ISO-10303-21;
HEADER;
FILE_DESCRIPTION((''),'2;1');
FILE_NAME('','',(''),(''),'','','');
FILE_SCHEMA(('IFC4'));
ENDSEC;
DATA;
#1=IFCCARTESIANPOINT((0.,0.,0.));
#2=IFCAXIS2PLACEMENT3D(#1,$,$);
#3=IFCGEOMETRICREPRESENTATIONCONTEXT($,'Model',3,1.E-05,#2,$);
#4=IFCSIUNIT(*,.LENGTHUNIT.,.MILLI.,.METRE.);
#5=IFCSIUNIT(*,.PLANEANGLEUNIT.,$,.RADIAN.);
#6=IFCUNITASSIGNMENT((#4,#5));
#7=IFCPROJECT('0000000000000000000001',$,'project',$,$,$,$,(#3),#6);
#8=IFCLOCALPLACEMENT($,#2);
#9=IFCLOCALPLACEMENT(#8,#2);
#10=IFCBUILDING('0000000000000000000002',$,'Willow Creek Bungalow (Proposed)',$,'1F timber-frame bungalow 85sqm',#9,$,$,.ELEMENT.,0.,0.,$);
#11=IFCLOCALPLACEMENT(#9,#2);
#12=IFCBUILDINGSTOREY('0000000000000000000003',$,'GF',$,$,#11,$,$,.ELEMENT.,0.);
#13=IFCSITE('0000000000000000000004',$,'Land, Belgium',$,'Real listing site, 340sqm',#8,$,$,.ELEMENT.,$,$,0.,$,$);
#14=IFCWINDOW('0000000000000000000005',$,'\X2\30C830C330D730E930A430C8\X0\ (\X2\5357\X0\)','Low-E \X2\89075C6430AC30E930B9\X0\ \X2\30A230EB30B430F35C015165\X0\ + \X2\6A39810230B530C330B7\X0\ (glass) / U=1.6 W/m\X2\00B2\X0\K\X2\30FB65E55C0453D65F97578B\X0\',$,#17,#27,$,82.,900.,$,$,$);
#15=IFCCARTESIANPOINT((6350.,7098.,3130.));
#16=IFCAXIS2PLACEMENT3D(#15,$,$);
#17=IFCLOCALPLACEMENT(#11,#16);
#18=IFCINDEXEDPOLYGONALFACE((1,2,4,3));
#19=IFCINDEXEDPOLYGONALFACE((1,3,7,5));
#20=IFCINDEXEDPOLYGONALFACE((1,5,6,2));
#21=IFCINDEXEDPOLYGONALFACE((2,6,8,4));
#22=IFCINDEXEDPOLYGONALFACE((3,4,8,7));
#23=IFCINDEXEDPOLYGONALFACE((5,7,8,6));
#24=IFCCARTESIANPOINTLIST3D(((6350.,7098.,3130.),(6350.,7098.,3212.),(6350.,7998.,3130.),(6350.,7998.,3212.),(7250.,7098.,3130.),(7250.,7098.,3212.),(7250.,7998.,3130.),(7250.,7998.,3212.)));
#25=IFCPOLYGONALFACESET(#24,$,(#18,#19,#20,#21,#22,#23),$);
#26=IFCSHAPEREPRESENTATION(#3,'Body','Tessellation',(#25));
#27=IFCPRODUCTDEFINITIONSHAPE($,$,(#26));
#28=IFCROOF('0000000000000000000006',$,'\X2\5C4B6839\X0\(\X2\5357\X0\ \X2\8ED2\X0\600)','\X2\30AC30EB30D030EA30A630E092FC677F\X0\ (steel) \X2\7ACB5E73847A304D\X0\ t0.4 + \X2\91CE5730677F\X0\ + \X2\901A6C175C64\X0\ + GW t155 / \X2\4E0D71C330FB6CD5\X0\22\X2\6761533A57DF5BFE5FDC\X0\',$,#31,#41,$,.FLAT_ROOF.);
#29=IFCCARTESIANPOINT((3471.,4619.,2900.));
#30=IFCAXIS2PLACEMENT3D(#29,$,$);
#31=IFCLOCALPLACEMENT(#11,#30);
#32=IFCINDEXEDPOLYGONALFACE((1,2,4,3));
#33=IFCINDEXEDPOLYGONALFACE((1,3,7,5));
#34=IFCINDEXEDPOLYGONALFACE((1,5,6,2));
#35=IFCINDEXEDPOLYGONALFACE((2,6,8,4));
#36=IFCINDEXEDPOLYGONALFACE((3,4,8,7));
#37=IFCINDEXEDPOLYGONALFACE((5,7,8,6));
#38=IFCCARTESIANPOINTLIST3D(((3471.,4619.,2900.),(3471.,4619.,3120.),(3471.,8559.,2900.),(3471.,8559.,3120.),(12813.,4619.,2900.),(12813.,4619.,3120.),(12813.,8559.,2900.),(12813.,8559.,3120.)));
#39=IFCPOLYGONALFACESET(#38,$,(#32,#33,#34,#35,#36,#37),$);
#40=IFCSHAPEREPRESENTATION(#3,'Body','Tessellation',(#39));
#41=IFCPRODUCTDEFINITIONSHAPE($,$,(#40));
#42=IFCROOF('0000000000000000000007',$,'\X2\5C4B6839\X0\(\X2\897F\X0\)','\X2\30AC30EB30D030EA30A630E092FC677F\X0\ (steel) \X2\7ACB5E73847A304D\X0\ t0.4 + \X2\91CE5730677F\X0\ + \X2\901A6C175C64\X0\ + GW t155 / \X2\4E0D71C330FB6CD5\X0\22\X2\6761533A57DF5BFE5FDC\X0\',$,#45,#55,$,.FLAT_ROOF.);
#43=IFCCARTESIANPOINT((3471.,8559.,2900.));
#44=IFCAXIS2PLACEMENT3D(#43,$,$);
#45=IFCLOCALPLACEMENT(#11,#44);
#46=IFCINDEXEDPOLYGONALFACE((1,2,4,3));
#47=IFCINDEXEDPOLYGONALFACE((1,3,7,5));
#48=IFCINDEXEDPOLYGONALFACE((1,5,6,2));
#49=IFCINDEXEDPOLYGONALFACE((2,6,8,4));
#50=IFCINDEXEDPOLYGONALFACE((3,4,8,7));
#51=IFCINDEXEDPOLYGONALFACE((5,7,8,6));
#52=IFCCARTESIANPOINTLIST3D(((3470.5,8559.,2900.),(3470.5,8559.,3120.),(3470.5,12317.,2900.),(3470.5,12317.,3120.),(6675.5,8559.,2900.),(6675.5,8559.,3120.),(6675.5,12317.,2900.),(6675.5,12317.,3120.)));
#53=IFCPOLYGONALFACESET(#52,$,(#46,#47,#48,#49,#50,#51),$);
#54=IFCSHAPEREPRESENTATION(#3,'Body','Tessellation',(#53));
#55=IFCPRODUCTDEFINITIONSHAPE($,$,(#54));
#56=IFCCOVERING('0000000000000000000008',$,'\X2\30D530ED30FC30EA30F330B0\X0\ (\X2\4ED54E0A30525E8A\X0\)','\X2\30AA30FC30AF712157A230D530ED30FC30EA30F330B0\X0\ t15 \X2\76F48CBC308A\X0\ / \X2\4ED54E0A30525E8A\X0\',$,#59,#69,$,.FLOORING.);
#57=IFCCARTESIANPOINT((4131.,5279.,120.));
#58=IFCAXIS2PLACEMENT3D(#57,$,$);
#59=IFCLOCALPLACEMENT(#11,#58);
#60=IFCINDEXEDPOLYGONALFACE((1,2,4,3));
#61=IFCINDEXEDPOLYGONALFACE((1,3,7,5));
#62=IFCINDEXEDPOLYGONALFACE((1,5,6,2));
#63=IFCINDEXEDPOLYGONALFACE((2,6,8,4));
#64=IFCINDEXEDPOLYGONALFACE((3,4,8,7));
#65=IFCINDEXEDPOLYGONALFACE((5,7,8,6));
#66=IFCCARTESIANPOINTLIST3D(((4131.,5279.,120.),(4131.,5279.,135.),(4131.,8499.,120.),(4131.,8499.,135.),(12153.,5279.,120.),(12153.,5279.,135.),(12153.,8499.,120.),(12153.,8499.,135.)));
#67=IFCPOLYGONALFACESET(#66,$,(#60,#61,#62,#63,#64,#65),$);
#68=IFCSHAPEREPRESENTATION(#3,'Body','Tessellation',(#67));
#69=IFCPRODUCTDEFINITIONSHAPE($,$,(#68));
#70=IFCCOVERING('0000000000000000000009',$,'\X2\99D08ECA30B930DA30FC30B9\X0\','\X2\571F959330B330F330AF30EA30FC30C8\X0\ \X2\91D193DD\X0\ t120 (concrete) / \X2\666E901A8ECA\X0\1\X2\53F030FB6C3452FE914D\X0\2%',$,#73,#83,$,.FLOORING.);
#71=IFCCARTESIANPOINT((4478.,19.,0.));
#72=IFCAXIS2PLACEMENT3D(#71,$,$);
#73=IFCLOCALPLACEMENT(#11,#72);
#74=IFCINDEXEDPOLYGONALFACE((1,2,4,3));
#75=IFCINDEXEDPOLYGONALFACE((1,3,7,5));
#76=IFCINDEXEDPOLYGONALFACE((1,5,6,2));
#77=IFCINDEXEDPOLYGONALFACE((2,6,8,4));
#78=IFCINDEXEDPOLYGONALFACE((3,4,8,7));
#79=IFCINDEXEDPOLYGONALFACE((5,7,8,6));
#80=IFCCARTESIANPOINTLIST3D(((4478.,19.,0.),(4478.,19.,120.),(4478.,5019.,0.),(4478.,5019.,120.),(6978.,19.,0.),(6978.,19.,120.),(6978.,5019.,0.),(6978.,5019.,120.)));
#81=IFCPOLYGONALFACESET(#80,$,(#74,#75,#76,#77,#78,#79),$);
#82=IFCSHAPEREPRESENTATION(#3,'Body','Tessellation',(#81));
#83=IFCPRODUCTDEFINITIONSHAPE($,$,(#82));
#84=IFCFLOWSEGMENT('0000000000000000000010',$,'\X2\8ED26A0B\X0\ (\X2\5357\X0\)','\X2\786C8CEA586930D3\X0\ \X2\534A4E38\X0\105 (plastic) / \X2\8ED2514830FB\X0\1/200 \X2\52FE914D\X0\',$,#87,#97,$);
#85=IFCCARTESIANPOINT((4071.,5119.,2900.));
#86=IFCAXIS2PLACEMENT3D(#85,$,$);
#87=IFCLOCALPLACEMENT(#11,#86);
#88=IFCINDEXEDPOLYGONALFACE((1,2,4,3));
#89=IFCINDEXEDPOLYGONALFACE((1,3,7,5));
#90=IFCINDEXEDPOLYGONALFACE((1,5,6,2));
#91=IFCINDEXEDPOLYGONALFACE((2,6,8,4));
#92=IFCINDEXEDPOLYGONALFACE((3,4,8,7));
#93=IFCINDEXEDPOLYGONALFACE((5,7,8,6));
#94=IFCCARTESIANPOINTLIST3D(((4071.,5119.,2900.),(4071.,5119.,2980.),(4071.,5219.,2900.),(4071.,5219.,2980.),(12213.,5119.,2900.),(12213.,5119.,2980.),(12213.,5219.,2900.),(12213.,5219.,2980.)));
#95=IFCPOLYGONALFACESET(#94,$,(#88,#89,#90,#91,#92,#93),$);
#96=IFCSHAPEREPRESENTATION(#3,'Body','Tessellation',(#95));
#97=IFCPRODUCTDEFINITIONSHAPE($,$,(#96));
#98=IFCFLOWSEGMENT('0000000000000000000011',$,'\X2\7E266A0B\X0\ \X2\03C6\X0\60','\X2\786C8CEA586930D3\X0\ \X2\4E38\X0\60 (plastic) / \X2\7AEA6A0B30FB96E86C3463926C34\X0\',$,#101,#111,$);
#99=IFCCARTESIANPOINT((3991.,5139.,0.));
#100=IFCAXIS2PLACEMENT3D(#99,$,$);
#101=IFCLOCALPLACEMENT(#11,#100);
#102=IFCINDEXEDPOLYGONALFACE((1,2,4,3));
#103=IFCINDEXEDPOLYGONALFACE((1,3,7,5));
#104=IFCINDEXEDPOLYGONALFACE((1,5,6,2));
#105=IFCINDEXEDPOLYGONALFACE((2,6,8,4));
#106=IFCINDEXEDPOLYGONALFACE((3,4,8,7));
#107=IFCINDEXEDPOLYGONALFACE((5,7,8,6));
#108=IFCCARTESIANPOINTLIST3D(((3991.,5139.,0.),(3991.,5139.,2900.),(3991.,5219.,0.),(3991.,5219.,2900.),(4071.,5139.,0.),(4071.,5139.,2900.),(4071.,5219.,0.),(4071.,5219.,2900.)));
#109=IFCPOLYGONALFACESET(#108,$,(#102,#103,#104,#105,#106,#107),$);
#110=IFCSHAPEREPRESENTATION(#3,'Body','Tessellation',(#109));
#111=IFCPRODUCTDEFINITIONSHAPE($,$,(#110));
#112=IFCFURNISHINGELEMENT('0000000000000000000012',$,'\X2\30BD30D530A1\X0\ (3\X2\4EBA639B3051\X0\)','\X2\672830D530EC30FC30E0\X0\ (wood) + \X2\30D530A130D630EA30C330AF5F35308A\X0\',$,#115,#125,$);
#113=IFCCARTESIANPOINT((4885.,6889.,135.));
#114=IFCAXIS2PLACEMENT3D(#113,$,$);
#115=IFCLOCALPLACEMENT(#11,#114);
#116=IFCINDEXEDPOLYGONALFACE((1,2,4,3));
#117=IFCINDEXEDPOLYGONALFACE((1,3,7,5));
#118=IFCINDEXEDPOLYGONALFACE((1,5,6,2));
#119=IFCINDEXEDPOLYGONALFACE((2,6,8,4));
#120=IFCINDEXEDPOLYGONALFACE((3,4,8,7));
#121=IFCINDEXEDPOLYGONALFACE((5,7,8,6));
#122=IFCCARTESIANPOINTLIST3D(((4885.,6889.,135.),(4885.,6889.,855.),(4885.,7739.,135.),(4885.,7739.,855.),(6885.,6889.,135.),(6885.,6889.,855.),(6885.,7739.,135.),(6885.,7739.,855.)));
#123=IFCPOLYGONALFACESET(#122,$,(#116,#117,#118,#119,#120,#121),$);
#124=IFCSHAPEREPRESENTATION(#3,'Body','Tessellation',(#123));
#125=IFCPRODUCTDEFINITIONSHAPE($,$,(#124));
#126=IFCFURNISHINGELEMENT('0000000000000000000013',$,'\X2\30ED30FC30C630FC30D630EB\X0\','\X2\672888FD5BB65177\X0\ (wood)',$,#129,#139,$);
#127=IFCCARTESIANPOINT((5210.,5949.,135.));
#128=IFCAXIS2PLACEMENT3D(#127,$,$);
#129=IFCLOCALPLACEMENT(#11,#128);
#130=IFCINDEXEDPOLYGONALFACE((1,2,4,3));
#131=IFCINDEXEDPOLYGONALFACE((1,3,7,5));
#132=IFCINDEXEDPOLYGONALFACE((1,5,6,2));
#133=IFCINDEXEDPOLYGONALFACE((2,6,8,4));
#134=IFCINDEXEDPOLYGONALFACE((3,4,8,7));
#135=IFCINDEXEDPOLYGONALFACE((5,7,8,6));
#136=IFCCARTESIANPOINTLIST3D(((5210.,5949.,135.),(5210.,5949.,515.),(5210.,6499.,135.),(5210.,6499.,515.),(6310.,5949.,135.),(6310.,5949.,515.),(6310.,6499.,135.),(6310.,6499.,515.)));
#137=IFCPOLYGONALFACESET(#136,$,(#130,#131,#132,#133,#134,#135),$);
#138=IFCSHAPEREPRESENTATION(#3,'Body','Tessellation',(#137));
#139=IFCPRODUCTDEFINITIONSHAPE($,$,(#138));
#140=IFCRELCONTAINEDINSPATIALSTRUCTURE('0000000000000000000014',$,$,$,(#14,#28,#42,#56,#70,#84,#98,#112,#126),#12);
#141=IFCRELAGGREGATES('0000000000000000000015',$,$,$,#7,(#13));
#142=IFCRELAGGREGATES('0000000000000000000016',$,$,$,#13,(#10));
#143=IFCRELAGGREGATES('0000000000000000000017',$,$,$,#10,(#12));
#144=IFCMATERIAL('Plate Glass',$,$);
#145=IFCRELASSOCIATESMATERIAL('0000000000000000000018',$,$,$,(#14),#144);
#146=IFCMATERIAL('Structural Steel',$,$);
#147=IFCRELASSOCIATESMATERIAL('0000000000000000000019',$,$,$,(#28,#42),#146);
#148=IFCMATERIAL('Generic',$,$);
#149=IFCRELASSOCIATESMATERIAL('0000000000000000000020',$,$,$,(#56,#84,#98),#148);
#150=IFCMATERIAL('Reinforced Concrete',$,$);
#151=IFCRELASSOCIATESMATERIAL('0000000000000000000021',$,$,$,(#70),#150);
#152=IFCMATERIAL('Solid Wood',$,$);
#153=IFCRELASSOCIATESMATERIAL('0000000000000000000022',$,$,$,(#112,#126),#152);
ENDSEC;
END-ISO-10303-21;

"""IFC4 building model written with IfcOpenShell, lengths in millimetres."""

from ifc_helpers import new_model, si_unit, frame, frame_2d, origin, place, context, project, spatial, rectangle, extrude, material, element, save


model = new_model("IFC4")

# Units and contexts
model_context = context("Model", 3, precision=1e-05, world=origin())
ifc_project = project(units=[si_unit("LENGTHUNIT", "METRE", prefix="MILLI"), si_unit("PLANEANGLEUNIT", "RADIAN")], contexts=[model_context])

# Site, building, storey
site_placement = place(None, origin())
site = spatial("IfcSite", under=ifc_project, at=site_placement, Name="Land, Belgium", ObjectType="Real listing site, 340sqm", CompositionType="ELEMENT", RefElevation=0.0)
building_placement = place(site_placement, origin())
building = spatial("IfcBuilding", under=site, at=building_placement, Name="Willow Creek Bungalow (Proposed)", ObjectType="1F timber-frame bungalow 85sqm", CompositionType="ELEMENT", ElevationOfRefHeight=0.0, ElevationOfTerrain=0.0)
storey_placement = place(building_placement, origin())
storey = spatial("IfcBuildingStorey", under=building, at=storey_placement, Name="GF", CompositionType="ELEMENT", Elevation=0.0)

# Shared definitions
ifc_material_1 = material(Name="Solid Wood")

# Shared definitions
ifc_material_2 = material(Name="Reinforced Concrete")

# Shared definitions
ifc_material_3 = material(Name="Plate Glass")

# Window
window_1_placement = place(storey_placement, frame((6350.0, 7098.0, 3130.0)))
element("IfcWindow", 1, at=window_1_placement, inside=storey, material=ifc_material_3, Name="トップライト (南)", Description="Low-E 複層ガラス アルゴン封入 + 樹脂サッシ (glass) / U=1.6 W/m²K・日射取得型", OverallHeight=82.0, OverallWidth=900.0, context=model_context, shape_type="SweptSolid", body=[
    extrude(rectangle(XDim=900.0, YDim=900.0, at=frame_2d((450.0, 450.0))), frame((6350.0, 7098.0, 3130.0)), (0.0, 0.0, 1.0), 82.0),
])

# Roofs
ifc_material_4 = material(Name="Structural Steel")
roof_1_placement = place(storey_placement, frame((3471.0, 4619.0, 2900.0)))
element("IfcRoof", 2, at=roof_1_placement, inside=storey, material=ifc_material_4, Name="屋根(南 軒600)", Description="ガルバリウム鋼板 (steel) 立平葺き t0.4 + 野地板 + 通気層 + GW t155 / 不燃・法22条区域対応", PredefinedType="FLAT_ROOF", context=model_context, shape_type="SweptSolid", body=[
    extrude(rectangle(XDim=9342.0, YDim=3940.0, at=frame_2d((4671.0, 1970.0))), frame((3471.0, 4619.0, 2900.0)), (0.0, 0.0, 1.0), 220.0),
])
roof_2_placement = place(storey_placement, frame((3471.0, 8559.0, 2900.0)))
element("IfcRoof", 3, at=roof_2_placement, inside=storey, material=ifc_material_4, Name="屋根(西)", Description="ガルバリウム鋼板 (steel) 立平葺き t0.4 + 野地板 + 通気層 + GW t155 / 不燃・法22条区域対応", PredefinedType="FLAT_ROOF", context=model_context, shape_type="SweptSolid", body=[
    extrude(rectangle(XDim=3205.0, YDim=3758.0, at=frame_2d((1602.0, 1879.0))), frame((3471.0, 8559.0, 2900.0)), (0.0, 0.0, 1.0), 220.0),
])

# Coverings
ifc_material_5 = material(Name="Generic")
covering_1_placement = place(storey_placement, frame((4131.0, 5279.0, 120.0)))
element("IfcCovering", 4, at=covering_1_placement, inside=storey, material=ifc_material_5, Name="フローリング (仕上げ床)", Description="オーク無垢フローリング t15 直貼り / 仕上げ床", PredefinedType="FLOORING", context=model_context, shape_type="SweptSolid", body=[
    extrude(rectangle(XDim=8022.0, YDim=3220.0, at=frame_2d((4011.0, 1610.0))), frame((4131.0, 5279.0, 120.0)), (0.0, 0.0, 1.0), 15.0),
])
covering_2_placement = place(storey_placement, frame((4478.0, 19.0, 0.0)))
element("IfcCovering", 5, at=covering_2_placement, inside=storey, material=ifc_material_2, Name="駐車スペース", Description="土間コンクリート 金鏝 t120 (concrete) / 普通車1台・水勾配2%", PredefinedType="FLOORING", context=model_context, shape_type="SweptSolid", body=[
    extrude(rectangle(XDim=2500.0, YDim=5000.0, at=frame_2d((1250.0, 2500.0))), frame((4478.0, 19.0, 0.0)), (0.0, 0.0, 1.0), 120.0),
])

# Flow segments
flow_segment_1_placement = place(storey_placement, frame((4071.0, 5119.0, 2900.0)))
element("IfcFlowSegment", 6, at=flow_segment_1_placement, inside=storey, material=ifc_material_5, Name="軒樋 (南)", Description="硬質塩ビ 半丸105 (plastic) / 軒先・1/200 勾配", context=model_context, shape_type="SweptSolid", body=[
    extrude(rectangle(XDim=8142.0, YDim=100.0, at=frame_2d((4071.0, 50.0))), frame((4071.0, 5119.0, 2900.0)), (0.0, 0.0, 1.0), 80.0),
])
flow_segment_2_placement = place(storey_placement, frame((3991.0, 5139.0, 0.0)))
element("IfcFlowSegment", 7, at=flow_segment_2_placement, inside=storey, material=ifc_material_5, Name="縦樋 φ60", Description="硬質塩ビ 丸60 (plastic) / 竪樋・雨水排水", context=model_context, shape_type="SweptSolid", body=[
    extrude(rectangle(XDim=80.0, YDim=80.0, at=frame_2d((40.0, 40.0))), frame((3991.0, 5139.0, 0.0)), (0.0, 0.0, 1.0), 2900.0),
])

# Furnishing elements
furnishing_1_placement = place(storey_placement, frame((4885.0, 6889.0, 135.0)))
element("IfcFurnishingElement", 8, at=furnishing_1_placement, inside=storey, material=ifc_material_1, Name="ソファ (3人掛け)", Description="木フレーム (wood) + ファブリック張り", context=model_context, shape_type="SweptSolid", body=[
    extrude(rectangle(XDim=2000.0, YDim=850.0, at=frame_2d((1000.0, 425.0))), frame((4885.0, 6889.0, 135.0)), (0.0, 0.0, 1.0), 720.0),
])
furnishing_2_placement = place(storey_placement, frame((5210.0, 5949.0, 135.0)))
element("IfcFurnishingElement", 9, at=furnishing_2_placement, inside=storey, material=ifc_material_1, Name="ローテーブル", Description="木製家具 (wood)", context=model_context, shape_type="SweptSolid", body=[
    extrude(rectangle(XDim=1100.0, YDim=550.0, at=frame_2d((550.0, 275.0))), frame((5210.0, 5949.0, 135.0)), (0.0, 0.0, 1.0), 380.0),
])

save(model, "model.ifc")
